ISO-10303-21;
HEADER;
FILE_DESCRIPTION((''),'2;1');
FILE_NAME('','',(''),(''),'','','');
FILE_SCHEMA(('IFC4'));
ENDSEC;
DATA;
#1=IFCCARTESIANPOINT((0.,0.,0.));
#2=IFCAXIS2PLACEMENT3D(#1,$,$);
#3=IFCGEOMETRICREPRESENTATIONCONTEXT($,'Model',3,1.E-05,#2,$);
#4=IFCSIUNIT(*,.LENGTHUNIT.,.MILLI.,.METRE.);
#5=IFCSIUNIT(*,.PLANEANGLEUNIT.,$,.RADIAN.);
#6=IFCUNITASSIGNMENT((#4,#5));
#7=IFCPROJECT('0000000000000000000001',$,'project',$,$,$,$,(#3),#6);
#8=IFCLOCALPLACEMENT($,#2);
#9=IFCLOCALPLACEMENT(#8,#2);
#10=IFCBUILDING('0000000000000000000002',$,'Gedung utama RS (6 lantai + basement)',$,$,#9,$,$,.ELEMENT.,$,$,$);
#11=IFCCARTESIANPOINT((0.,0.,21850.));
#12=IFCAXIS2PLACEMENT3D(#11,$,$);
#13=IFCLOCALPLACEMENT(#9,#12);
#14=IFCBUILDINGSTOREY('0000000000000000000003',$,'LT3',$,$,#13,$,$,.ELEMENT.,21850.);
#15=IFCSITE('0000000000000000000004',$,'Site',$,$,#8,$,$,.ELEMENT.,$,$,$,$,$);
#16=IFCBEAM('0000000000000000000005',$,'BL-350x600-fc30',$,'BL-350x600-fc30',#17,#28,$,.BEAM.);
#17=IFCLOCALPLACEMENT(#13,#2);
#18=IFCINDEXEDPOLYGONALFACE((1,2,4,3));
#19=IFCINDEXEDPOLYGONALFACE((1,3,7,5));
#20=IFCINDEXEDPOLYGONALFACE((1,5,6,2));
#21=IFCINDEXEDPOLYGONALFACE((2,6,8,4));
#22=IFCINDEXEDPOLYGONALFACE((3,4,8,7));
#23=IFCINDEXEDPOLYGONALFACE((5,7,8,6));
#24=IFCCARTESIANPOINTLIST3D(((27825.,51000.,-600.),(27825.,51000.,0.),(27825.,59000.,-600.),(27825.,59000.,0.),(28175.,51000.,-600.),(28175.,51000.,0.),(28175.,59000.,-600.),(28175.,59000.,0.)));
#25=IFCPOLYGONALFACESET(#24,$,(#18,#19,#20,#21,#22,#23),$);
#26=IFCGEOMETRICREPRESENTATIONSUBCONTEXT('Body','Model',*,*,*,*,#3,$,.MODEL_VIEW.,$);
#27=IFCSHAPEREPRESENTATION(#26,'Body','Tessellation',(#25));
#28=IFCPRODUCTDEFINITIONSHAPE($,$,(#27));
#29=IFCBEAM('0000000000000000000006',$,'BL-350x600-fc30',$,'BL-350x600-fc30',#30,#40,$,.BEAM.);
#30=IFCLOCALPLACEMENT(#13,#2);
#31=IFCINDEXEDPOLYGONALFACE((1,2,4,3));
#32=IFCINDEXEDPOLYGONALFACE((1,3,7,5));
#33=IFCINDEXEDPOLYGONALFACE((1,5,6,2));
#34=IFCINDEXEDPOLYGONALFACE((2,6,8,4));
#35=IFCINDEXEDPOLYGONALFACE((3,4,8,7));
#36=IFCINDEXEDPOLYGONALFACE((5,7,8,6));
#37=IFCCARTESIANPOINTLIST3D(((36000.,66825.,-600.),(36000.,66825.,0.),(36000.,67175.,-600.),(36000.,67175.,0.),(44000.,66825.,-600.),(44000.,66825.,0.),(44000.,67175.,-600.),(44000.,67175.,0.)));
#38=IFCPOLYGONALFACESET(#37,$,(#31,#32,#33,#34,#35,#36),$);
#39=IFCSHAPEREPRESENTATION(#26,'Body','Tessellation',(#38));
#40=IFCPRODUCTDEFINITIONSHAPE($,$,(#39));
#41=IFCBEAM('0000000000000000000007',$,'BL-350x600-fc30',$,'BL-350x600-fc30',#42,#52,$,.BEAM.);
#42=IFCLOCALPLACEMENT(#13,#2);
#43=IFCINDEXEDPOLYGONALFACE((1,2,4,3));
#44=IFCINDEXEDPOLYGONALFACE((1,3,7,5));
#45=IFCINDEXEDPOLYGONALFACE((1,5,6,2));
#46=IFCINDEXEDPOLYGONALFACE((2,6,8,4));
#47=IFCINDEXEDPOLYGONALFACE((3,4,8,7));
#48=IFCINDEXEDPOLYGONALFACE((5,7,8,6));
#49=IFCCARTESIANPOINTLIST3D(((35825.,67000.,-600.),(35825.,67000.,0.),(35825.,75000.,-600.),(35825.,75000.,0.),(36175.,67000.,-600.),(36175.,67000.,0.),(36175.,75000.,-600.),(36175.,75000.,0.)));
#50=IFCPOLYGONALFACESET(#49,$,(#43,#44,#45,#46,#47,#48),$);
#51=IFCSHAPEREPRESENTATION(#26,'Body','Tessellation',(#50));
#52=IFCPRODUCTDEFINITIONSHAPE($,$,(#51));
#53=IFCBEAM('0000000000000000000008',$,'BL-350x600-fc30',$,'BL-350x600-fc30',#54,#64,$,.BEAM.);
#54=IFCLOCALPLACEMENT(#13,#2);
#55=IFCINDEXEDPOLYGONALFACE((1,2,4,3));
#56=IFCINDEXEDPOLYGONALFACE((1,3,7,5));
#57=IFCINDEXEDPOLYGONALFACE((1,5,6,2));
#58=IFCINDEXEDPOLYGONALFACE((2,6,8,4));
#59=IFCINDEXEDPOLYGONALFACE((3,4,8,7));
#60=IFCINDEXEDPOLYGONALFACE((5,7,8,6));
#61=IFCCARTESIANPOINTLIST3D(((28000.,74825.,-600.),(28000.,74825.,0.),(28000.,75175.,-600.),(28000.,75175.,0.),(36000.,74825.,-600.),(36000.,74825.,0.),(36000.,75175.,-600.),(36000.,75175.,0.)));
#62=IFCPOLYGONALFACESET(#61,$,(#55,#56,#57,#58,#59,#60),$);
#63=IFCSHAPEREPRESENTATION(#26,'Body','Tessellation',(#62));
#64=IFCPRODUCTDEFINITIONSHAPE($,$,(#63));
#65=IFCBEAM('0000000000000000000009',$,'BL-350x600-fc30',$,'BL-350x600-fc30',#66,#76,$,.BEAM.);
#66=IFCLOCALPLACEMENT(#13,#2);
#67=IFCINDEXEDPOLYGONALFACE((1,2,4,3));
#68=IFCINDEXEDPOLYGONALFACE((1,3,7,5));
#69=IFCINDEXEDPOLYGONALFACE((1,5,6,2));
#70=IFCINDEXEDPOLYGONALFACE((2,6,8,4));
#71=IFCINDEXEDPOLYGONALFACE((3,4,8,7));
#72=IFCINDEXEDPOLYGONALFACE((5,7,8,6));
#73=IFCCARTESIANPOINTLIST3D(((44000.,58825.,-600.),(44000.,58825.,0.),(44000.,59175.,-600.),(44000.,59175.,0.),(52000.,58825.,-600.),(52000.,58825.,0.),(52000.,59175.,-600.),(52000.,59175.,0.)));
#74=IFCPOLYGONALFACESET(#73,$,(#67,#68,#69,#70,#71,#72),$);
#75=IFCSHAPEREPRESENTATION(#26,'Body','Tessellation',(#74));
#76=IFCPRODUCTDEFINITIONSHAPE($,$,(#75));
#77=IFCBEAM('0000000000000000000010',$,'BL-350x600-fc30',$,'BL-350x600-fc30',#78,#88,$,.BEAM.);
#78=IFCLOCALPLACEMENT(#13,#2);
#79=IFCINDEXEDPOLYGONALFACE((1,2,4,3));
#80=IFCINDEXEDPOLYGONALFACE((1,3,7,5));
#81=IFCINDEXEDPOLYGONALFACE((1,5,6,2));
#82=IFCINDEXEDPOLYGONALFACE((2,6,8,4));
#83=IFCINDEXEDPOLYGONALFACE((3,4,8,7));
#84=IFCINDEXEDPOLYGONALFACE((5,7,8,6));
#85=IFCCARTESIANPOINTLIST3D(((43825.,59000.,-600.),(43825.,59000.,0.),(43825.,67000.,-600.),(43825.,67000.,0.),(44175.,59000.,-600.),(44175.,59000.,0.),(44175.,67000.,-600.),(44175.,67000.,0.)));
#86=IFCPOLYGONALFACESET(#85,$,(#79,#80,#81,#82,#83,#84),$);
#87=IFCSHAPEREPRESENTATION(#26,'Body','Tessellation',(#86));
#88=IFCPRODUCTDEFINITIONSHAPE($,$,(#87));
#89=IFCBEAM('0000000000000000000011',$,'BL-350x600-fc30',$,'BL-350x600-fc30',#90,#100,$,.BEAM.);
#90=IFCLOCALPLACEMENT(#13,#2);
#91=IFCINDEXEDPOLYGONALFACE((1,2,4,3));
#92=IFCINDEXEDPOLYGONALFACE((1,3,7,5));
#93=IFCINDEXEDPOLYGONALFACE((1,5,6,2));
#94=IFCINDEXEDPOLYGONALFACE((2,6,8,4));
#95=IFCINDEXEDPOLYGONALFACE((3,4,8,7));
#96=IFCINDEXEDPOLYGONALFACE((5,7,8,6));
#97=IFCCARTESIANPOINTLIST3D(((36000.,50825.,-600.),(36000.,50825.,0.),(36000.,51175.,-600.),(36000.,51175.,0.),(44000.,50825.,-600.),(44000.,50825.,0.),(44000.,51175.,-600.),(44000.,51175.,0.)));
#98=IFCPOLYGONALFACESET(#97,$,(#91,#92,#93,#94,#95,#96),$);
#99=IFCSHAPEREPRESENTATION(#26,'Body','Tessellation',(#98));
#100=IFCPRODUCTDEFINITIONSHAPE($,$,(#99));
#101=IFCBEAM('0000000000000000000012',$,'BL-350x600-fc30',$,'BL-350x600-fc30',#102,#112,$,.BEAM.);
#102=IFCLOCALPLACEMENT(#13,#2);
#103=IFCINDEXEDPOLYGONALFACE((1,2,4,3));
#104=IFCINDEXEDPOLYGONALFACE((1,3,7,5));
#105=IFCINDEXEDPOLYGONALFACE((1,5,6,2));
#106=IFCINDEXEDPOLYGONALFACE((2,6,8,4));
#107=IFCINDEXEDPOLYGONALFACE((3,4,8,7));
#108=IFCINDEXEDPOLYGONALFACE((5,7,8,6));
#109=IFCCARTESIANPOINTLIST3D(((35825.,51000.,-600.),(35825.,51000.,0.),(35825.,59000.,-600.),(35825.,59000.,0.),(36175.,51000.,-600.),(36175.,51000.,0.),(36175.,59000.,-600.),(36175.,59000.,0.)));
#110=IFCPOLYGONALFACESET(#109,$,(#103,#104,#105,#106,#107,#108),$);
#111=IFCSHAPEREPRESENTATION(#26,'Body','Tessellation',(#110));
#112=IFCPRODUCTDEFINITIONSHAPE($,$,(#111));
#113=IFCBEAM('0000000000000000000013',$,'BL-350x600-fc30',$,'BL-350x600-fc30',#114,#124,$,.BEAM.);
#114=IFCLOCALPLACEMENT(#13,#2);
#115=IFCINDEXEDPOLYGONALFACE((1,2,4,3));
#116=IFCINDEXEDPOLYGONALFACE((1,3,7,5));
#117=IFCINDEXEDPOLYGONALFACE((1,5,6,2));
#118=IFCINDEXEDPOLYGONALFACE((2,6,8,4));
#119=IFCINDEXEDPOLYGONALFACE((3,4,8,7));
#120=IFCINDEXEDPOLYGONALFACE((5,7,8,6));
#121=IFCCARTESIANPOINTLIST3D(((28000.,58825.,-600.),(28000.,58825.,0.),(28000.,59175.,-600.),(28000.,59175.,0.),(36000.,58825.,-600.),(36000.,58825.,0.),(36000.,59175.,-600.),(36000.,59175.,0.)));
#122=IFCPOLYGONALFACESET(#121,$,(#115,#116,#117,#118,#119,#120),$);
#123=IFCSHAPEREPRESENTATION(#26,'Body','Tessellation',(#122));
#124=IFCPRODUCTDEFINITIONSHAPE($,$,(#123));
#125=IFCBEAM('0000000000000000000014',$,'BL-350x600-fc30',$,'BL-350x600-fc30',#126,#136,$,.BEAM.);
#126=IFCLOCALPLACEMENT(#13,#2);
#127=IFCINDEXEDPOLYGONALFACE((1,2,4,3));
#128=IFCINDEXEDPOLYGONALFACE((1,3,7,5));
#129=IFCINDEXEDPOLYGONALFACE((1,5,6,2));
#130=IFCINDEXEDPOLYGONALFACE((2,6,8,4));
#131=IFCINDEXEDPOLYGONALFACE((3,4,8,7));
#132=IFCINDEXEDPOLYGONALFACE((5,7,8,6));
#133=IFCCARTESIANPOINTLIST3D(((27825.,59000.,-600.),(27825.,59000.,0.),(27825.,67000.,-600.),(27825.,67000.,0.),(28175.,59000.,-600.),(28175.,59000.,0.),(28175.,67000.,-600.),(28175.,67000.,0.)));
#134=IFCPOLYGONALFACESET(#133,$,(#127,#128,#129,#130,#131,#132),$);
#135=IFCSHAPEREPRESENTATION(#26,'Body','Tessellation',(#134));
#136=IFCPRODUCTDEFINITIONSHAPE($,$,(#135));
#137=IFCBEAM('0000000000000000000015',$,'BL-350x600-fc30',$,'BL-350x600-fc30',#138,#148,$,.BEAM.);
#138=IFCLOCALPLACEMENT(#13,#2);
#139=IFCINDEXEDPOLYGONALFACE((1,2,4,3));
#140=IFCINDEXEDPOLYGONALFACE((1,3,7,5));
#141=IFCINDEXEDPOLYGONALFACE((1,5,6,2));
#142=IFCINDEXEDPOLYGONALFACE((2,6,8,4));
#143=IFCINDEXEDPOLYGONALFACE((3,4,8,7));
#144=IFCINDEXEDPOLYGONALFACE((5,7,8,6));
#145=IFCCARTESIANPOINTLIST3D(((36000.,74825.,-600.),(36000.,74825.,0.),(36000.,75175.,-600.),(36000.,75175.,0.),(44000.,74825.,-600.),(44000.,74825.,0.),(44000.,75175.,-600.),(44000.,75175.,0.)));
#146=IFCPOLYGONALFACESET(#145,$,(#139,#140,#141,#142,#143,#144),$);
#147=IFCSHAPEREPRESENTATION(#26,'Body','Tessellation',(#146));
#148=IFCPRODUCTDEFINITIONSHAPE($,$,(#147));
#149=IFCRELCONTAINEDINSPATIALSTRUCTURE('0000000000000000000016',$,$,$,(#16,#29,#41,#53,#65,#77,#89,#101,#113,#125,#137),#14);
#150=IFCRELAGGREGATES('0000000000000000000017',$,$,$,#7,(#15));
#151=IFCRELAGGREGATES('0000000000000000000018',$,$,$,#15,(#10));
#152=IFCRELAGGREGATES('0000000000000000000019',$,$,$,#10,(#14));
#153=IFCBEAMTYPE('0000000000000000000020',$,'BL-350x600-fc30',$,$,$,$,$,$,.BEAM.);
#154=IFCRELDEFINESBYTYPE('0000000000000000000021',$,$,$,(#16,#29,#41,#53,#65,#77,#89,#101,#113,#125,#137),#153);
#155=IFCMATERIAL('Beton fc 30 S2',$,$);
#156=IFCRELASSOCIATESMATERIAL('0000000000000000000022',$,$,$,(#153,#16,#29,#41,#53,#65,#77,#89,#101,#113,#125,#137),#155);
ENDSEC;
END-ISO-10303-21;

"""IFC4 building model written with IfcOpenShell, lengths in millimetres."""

from ifc_helpers import new_model, si_unit, frame, origin, origin_2d, place, context, subcontext, project, spatial, rectangle, extrude, material, material_profile, profile_set, profile_usage, type_object, element, save


model = new_model("IFC4")

# Units and contexts
model_context = context("Model", 3, precision=1e-05, world=origin())
body_context = subcontext(model_context, "Body", "Model", "MODEL_VIEW")
ifc_project = project(units=[si_unit("LENGTHUNIT", "METRE", prefix="MILLI"), si_unit("PLANEANGLEUNIT", "RADIAN")], contexts=[model_context])

# Site, building, storey
site_placement = place(None, origin())
site = spatial("IfcSite", under=ifc_project, at=site_placement, Name="Site", CompositionType="ELEMENT")
building_placement = place(site_placement, origin())
building = spatial("IfcBuilding", under=site, at=building_placement, Name="Gedung utama RS (6 lantai + basement)", CompositionType="ELEMENT")
storey_placement = place(building_placement, frame((0.0, 0.0, 21850.0)))
storey = spatial("IfcBuildingStorey", under=building, at=storey_placement, Name="LT3", CompositionType="ELEMENT", Elevation=21850.0)

# Beams
ifc_material = material(Name="Beton fc 30 S2")
ifc_material_profile_1 = material_profile(ifc_material, rectangle(XDim=350.0, YDim=600.0, at=origin_2d()), Name="BL-350x600-fc30")
ifc_profile_set_1 = profile_set([ifc_material_profile_1], Name="BL-350x600-fc30")
ifc_profile_usage_1 = profile_usage(ifc_profile_set_1, cardinal=8)
beam_type = type_object("IfcBeamType", Name="BL-350x600-fc30", PredefinedType="BEAM", material=ifc_profile_set_1)
beam_1_placement = place(storey_placement, frame((28000.0, 51000.0, -300.0)))
element("IfcBeam", 1, at=beam_1_placement, inside=storey, type_object=beam_type, material=ifc_profile_usage_1, Name="BL-350x600-fc30", ObjectType="BL-350x600-fc30", PredefinedType="BEAM", context=body_context, shape_type="SweptSolid", body=[
    extrude(rectangle(XDim=350.0, YDim=600.0, at=origin_2d()), frame((0.0, 0.0, 0.0), z_axis=(0.0, 1.0, 0.0), x_axis=(-1.0, 0.0, 0.0)), (0.0, 0.0, 1.0), 8000.0),
])
beam_2_placement = place(storey_placement, frame((36000.0, 67000.0, -300.0)))
element("IfcBeam", 2, at=beam_2_placement, inside=storey, type_object=beam_type, material=ifc_profile_usage_1, Name="BL-350x600-fc30", ObjectType="BL-350x600-fc30", PredefinedType="BEAM", context=body_context, shape_type="SweptSolid", body=[
    extrude(rectangle(XDim=350.0, YDim=600.0, at=origin_2d()), frame((0.0, 0.0, 0.0), z_axis=(1.0, 0.0, 0.0), x_axis=(0.0, 1.0, 0.0)), (0.0, 0.0, 1.0), 8000.0),
])
beam_3_placement = place(storey_placement, frame((36000.0, 67000.0, -300.0)))
element("IfcBeam", 3, at=beam_3_placement, inside=storey, type_object=beam_type, material=ifc_profile_usage_1, Name="BL-350x600-fc30", ObjectType="BL-350x600-fc30", PredefinedType="BEAM", context=body_context, shape_type="SweptSolid", body=[
    extrude(rectangle(XDim=350.0, YDim=600.0, at=origin_2d()), frame((0.0, 0.0, 0.0), z_axis=(0.0, 1.0, 0.0), x_axis=(-1.0, 0.0, 0.0)), (0.0, 0.0, 1.0), 8000.0),
])
for number, where, name in (
    (4, (28000.0, 75000.0, -300.0), "BL-350x600-fc30"),
    (5, (44000.0, 59000.0, -300.0), "BL-350x600-fc30"),
):
    element("IfcBeam", number, at=place(storey_placement, frame(where)), inside=storey, type_object=beam_type, material=ifc_profile_usage_1, Name=name, ObjectType="BL-350x600-fc30", PredefinedType="BEAM", context=body_context, shape_type="SweptSolid", body=[
        extrude(rectangle(XDim=350.0, YDim=600.0, at=origin_2d()), frame((0.0, 0.0, 0.0), z_axis=(1.0, 0.0, 0.0), x_axis=(0.0, 1.0, 0.0)), (0.0, 0.0, 1.0), 8000.0),
    ])
beam_4_placement = place(storey_placement, frame((44000.0, 59000.0, -300.0)))
element("IfcBeam", 6, at=beam_4_placement, inside=storey, type_object=beam_type, material=ifc_profile_usage_1, Name="BL-350x600-fc30", ObjectType="BL-350x600-fc30", PredefinedType="BEAM", context=body_context, shape_type="SweptSolid", body=[
    extrude(rectangle(XDim=350.0, YDim=600.0, at=origin_2d()), frame((0.0, 0.0, 0.0), z_axis=(0.0, 1.0, 0.0), x_axis=(-1.0, 0.0, 0.0)), (0.0, 0.0, 1.0), 8000.0),
])
beam_5_placement = place(storey_placement, frame((36000.0, 51000.0, -300.0)))
element("IfcBeam", 7, at=beam_5_placement, inside=storey, type_object=beam_type, material=ifc_profile_usage_1, Name="BL-350x600-fc30", ObjectType="BL-350x600-fc30", PredefinedType="BEAM", context=body_context, shape_type="SweptSolid", body=[
    extrude(rectangle(XDim=350.0, YDim=600.0, at=origin_2d()), frame((0.0, 0.0, 0.0), z_axis=(1.0, 0.0, 0.0), x_axis=(0.0, 1.0, 0.0)), (0.0, 0.0, 1.0), 8000.0),
])
beam_6_placement = place(storey_placement, frame((36000.0, 51000.0, -300.0)))
element("IfcBeam", 8, at=beam_6_placement, inside=storey, type_object=beam_type, material=ifc_profile_usage_1, Name="BL-350x600-fc30", ObjectType="BL-350x600-fc30", PredefinedType="BEAM", context=body_context, shape_type="SweptSolid", body=[
    extrude(rectangle(XDim=350.0, YDim=600.0, at=origin_2d()), frame((0.0, 0.0, 0.0), z_axis=(0.0, 1.0, 0.0), x_axis=(-1.0, 0.0, 0.0)), (0.0, 0.0, 1.0), 8000.0),
])
beam_7_placement = place(storey_placement, frame((28000.0, 59000.0, -300.0)))
element("IfcBeam", 9, at=beam_7_placement, inside=storey, type_object=beam_type, material=ifc_profile_usage_1, Name="BL-350x600-fc30", ObjectType="BL-350x600-fc30", PredefinedType="BEAM", context=body_context, shape_type="SweptSolid", body=[
    extrude(rectangle(XDim=350.0, YDim=600.0, at=origin_2d()), frame((0.0, 0.0, 0.0), z_axis=(1.0, 0.0, 0.0), x_axis=(0.0, 1.0, 0.0)), (0.0, 0.0, 1.0), 8000.0),
])
beam_8_placement = place(storey_placement, frame((28000.0, 59000.0, -300.0)))
element("IfcBeam", 10, at=beam_8_placement, inside=storey, type_object=beam_type, material=ifc_profile_usage_1, Name="BL-350x600-fc30", ObjectType="BL-350x600-fc30", PredefinedType="BEAM", context=body_context, shape_type="SweptSolid", body=[
    extrude(rectangle(XDim=350.0, YDim=600.0, at=origin_2d()), frame((0.0, 0.0, 0.0), z_axis=(0.0, 1.0, 0.0), x_axis=(-1.0, 0.0, 0.0)), (0.0, 0.0, 1.0), 8000.0),
])
beam_9_placement = place(storey_placement, frame((36000.0, 75000.0, -300.0)))
element("IfcBeam", 11, at=beam_9_placement, inside=storey, type_object=beam_type, material=ifc_profile_usage_1, Name="BL-350x600-fc30", ObjectType="BL-350x600-fc30", PredefinedType="BEAM", context=body_context, shape_type="SweptSolid", body=[
    extrude(rectangle(XDim=350.0, YDim=600.0, at=origin_2d()), frame((0.0, 0.0, 0.0), z_axis=(1.0, 0.0, 0.0), x_axis=(0.0, 1.0, 0.0)), (0.0, 0.0, 1.0), 8000.0),
])

save(model, "model.ifc")
